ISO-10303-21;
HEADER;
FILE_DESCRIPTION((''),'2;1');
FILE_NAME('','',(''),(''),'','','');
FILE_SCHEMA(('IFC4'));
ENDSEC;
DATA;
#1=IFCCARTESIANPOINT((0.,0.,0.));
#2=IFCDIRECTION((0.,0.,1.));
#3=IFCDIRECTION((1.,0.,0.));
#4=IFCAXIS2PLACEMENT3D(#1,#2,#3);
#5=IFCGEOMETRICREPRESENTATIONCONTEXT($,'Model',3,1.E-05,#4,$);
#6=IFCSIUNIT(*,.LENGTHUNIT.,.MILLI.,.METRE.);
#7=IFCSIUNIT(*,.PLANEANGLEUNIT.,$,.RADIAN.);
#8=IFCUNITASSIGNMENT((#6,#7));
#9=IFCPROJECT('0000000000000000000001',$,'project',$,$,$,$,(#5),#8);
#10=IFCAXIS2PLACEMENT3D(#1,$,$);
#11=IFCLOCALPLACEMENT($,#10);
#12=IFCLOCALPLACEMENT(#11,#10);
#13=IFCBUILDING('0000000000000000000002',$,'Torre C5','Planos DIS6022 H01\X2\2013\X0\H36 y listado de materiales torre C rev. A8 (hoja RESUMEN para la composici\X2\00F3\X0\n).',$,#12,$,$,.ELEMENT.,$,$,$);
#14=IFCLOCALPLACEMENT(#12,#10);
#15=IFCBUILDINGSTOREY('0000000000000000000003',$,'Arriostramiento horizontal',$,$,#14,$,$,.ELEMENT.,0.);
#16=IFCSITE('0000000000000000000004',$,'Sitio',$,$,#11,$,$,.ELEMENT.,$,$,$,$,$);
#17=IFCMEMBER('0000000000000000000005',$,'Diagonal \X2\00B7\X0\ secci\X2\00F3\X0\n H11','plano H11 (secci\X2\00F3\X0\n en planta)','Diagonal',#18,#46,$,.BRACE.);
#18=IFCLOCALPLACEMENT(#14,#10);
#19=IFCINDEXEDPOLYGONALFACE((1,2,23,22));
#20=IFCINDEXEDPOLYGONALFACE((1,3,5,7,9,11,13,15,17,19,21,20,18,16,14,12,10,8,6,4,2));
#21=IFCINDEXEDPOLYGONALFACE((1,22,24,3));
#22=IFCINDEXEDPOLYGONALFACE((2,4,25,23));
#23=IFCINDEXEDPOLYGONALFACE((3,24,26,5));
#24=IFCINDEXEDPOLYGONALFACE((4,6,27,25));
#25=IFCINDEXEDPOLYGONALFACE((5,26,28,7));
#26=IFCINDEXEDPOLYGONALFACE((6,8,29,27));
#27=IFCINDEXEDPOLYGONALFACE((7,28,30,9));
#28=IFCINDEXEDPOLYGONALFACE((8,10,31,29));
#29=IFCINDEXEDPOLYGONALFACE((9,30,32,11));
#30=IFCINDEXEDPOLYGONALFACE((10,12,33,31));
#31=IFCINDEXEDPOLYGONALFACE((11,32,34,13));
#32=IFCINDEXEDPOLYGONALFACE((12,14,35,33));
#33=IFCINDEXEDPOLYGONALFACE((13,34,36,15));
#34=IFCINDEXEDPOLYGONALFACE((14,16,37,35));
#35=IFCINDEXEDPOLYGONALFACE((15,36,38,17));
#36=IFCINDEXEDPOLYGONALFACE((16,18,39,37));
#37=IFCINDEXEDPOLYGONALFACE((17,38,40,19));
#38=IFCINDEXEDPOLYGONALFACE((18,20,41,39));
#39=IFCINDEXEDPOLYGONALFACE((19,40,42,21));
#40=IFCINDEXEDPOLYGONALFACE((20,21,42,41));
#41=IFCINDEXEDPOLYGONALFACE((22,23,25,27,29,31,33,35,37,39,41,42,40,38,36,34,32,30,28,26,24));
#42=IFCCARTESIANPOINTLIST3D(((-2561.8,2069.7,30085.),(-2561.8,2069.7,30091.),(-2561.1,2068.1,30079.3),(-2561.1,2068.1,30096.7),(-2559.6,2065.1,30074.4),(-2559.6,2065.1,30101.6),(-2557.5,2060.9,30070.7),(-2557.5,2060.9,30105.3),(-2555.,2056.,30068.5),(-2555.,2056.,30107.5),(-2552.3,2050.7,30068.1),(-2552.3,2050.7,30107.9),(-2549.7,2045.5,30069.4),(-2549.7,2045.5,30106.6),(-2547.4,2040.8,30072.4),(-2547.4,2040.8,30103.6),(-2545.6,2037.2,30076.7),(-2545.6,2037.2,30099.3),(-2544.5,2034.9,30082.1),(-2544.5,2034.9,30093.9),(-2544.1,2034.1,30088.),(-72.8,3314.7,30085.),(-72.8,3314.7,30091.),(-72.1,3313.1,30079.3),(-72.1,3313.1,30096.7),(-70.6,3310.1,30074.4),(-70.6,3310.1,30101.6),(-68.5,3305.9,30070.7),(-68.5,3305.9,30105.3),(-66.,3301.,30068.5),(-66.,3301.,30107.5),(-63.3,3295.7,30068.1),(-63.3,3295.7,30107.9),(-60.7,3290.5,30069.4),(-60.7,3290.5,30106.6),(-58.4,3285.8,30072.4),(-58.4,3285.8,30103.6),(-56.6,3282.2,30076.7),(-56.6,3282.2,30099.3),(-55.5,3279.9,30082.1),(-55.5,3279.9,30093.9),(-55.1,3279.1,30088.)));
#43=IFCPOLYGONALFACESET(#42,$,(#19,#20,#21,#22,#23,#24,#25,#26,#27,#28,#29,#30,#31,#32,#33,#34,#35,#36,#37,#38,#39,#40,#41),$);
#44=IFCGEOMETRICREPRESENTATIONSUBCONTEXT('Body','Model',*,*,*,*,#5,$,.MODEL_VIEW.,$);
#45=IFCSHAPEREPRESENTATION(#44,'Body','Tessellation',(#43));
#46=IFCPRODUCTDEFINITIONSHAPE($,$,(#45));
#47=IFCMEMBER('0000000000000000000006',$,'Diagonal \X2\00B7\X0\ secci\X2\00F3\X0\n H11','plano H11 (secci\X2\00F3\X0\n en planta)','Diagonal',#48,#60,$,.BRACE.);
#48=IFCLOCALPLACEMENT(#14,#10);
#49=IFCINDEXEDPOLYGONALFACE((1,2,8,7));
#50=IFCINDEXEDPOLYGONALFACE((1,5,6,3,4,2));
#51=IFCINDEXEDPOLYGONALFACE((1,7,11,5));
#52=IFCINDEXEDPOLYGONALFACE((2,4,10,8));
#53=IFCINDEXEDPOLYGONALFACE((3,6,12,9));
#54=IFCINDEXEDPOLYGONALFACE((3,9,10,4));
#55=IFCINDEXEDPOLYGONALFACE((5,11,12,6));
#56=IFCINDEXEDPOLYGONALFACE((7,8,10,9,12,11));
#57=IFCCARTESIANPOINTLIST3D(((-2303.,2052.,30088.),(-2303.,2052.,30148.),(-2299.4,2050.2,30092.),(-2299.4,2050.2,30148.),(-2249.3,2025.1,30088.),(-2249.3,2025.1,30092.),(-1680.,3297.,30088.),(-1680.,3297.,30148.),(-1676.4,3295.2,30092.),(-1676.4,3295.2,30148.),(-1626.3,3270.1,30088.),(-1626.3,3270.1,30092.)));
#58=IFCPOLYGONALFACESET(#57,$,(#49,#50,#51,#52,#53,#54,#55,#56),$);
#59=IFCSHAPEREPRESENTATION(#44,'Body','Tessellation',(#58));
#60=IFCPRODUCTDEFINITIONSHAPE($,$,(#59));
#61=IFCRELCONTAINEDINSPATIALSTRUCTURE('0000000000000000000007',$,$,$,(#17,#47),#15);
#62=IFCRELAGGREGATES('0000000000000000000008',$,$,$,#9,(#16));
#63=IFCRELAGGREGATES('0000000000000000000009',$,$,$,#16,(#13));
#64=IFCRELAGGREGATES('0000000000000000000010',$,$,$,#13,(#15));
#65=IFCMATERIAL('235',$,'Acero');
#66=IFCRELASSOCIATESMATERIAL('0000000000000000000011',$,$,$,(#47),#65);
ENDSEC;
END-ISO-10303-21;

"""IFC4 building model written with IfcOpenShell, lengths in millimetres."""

from ifc_helpers import new_model, si_unit, frame, frame_2d, origin, origin_with_axes, place, context, subcontext, project, spatial, circle, l_section, extrude, material, element, save


model = new_model("IFC4")

# Units and contexts
model_context = context("Model", 3, precision=1e-05, world=origin_with_axes())
body_context = subcontext(model_context, "Body", "Model", "MODEL_VIEW")
ifc_project = project(units=[si_unit("LENGTHUNIT", "METRE", prefix="MILLI"), si_unit("PLANEANGLEUNIT", "RADIAN")], contexts=[model_context])

# Site, building, storey
site_placement = place(None, origin())
site = spatial("IfcSite", under=ifc_project, at=site_placement, Name="Sitio", CompositionType="ELEMENT")
building_placement = place(site_placement, origin())
building = spatial("IfcBuilding", under=site, at=building_placement, Name="Torre C5", Description="Planos DIS6022 H01–H36 y listado de materiales torre C rev. A8 (hoja RESUMEN para la composición).", CompositionType="ELEMENT")
storey_placement = place(building_placement, origin())
storey = spatial("IfcBuildingStorey", under=building, at=storey_placement, Name="Arriostramiento horizontal", CompositionType="ELEMENT", Elevation=0.0)

# Members
ifc_material = material(Name="235", Category="Acero")
member_1_placement = place(storey_placement, frame((-64.0, 3297.0, 30088.0), z_axis=(-0.894355, -0.447357, 0.0), x_axis=(0.447357, -0.894355, 0.0)))
element("IfcMember", 1, at=member_1_placement, inside=storey, Name="Diagonal · sección H11", Description="plano H11 (sección en planta)", ObjectType="Diagonal", PredefinedType="BRACE", context=body_context, shape_type="SweptSolid", body=[
    extrude(circle(Radius=20.0), None, (0.0, 0.0, 1.0), 2783.0),
])
member_2_placement = place(storey_placement, frame((-1680.0, 3297.0, 30088.0), z_axis=(-0.447501, -0.894283, 0.0), x_axis=(0.894283, -0.447501, 0.0)))
element("IfcMember", 2, at=member_2_placement, inside=storey, material=ifc_material, Name="Diagonal · sección H11", Description="plano H11 (sección en planta)", ObjectType="Diagonal", PredefinedType="BRACE", context=body_context, shape_type="SweptSolid", body=[
    extrude(l_section(Depth=60.0, Width=60.0, Thickness=4.0, at=frame_2d((30.0, 30.0))), None, (0.0, 0.0, 1.0), 1392.2),
])

save(model, "model.ifc")
